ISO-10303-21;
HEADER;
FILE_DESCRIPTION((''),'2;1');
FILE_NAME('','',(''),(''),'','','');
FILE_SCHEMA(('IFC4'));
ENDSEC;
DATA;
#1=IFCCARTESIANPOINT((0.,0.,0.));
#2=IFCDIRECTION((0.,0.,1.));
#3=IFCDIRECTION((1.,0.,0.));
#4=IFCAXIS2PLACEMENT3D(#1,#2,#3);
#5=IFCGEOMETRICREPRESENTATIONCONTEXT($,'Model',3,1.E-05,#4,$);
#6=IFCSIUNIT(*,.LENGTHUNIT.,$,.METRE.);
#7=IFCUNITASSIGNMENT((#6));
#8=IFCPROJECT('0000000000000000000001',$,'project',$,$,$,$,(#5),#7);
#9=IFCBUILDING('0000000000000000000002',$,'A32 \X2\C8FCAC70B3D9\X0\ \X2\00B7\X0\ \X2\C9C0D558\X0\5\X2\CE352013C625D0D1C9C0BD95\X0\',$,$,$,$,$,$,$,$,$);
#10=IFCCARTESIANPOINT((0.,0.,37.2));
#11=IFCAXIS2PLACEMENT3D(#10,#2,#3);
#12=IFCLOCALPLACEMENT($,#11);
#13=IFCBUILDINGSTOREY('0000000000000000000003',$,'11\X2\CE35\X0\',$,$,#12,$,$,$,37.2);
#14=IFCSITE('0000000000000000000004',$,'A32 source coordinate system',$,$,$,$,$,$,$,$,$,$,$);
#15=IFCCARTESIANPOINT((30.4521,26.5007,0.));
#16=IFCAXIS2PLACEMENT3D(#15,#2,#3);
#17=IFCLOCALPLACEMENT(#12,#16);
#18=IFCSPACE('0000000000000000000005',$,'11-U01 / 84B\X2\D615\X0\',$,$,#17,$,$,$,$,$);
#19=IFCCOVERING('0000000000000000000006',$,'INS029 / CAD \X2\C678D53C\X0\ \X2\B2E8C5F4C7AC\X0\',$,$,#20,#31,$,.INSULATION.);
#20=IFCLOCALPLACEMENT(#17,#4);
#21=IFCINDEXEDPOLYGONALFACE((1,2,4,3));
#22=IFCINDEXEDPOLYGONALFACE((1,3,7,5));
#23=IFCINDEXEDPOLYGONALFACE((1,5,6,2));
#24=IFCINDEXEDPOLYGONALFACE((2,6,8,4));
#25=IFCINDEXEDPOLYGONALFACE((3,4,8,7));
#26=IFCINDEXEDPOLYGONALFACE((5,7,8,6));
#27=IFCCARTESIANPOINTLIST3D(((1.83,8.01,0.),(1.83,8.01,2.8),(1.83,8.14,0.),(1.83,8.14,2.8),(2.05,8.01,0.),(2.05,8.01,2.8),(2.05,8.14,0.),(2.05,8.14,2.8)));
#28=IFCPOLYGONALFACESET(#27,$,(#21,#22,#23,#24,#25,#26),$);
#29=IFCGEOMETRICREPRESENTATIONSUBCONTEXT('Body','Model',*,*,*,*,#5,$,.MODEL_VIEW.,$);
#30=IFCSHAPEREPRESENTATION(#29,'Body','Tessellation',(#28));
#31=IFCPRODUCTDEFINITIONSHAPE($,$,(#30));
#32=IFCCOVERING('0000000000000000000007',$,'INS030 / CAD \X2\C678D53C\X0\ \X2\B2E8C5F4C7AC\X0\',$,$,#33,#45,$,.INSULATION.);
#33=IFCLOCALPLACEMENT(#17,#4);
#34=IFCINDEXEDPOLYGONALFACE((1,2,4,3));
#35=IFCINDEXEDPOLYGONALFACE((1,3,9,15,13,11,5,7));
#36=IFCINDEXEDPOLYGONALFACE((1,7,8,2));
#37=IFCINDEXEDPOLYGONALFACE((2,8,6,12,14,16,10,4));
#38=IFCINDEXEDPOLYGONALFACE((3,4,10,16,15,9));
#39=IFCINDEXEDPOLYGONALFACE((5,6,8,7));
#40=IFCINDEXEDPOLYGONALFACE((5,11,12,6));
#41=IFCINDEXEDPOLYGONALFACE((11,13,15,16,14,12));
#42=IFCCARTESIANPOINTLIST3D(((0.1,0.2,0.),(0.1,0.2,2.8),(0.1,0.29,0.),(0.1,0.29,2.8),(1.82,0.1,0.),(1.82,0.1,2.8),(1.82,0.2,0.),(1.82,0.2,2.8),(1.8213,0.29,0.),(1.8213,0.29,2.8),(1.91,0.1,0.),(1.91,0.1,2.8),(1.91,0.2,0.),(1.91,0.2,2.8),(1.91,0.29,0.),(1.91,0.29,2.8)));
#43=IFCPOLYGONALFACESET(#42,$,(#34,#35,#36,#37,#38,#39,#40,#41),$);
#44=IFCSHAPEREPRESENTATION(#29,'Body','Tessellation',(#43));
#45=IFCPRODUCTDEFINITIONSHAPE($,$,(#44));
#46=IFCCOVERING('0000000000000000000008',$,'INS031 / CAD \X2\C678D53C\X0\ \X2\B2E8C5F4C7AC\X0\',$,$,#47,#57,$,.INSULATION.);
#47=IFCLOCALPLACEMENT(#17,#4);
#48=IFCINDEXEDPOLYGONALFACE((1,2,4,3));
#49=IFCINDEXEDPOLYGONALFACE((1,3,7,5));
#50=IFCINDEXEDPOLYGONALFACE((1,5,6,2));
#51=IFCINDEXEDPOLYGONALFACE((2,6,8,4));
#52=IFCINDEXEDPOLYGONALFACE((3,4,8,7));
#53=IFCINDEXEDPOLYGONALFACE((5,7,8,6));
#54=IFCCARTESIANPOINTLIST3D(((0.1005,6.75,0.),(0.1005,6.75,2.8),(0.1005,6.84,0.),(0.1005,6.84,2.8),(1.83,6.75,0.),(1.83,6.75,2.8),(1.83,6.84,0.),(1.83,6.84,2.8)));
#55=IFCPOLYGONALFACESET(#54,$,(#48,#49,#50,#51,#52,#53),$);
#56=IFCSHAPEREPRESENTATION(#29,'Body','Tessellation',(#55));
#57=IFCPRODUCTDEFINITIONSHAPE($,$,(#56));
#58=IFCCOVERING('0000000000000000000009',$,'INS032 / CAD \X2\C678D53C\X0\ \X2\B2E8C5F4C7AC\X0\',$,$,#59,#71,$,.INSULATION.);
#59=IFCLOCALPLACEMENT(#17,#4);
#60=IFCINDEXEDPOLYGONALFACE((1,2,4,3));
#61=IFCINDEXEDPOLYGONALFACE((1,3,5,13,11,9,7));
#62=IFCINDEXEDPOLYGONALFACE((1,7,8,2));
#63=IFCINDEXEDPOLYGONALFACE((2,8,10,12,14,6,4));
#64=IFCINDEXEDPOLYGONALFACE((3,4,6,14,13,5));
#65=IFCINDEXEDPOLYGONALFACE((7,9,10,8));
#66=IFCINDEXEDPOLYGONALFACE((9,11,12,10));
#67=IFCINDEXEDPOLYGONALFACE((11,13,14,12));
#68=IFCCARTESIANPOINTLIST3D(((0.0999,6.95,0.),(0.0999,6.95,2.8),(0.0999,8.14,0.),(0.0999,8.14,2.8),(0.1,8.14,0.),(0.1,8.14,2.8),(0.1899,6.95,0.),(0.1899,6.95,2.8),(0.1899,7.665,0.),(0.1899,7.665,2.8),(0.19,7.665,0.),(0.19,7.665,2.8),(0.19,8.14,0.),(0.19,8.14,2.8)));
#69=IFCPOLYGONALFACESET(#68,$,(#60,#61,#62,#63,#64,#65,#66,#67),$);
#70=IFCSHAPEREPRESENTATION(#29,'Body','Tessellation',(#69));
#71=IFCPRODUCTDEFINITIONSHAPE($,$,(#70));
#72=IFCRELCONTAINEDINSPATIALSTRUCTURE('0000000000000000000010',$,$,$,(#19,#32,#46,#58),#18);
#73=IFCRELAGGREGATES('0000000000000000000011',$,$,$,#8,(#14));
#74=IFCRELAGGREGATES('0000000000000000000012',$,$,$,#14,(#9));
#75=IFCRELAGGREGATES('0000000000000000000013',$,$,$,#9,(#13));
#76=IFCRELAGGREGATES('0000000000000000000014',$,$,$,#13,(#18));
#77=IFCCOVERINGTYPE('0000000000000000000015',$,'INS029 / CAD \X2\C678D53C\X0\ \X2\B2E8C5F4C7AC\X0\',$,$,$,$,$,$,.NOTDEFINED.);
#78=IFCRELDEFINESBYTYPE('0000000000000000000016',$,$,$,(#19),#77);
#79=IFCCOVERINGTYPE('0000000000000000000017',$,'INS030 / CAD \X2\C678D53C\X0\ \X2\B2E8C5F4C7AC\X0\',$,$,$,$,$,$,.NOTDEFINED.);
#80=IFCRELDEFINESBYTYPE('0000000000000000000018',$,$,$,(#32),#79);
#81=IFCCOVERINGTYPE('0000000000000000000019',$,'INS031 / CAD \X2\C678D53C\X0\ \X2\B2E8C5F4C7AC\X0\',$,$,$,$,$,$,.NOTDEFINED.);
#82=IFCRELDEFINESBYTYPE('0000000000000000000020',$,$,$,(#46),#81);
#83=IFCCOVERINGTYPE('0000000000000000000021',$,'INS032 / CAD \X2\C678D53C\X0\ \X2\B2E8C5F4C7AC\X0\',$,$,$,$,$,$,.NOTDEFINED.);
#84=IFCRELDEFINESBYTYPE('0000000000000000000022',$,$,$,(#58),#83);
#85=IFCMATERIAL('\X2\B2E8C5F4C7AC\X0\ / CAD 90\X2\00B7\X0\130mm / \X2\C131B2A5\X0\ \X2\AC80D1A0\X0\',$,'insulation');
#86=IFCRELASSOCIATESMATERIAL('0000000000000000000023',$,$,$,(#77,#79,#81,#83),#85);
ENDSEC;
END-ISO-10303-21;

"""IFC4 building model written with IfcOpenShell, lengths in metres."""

from ifc_helpers import new_model, si_unit, frame, origin, origin_with_axes, place, context, subcontext, project, spatial, polyline, outline, extrude, source, transform, mapped, material, type_object, type_shapes, element, save


model = new_model("IFC4")

# Units and contexts
model_context = context("Model", 3, precision=1e-05, world=origin_with_axes())
body_context = subcontext(model_context, "Body", "Model", "MODEL_VIEW")
ifc_project = project(units=[si_unit("LENGTHUNIT", "METRE")], contexts=[model_context])

# Site, building, storey, space
storey_placement = place(None, frame((0.0, 0.0, 37.2), z_axis=(0.0, 0.0, 1.0), x_axis=(1.0, 0.0, 0.0)))
space_placement = place(storey_placement, frame((30.4521, 26.5007, 0.0), z_axis=(0.0, 0.0, 1.0), x_axis=(1.0, 0.0, 0.0)))
site = spatial("IfcSite", under=ifc_project, Name="A32 source coordinate system")
building = spatial("IfcBuilding", under=site, Name="A32 주거동 · 지하5층–옥탑지붕")
storey = spatial("IfcBuildingStorey", under=building, at=storey_placement, Name="11층", Elevation=37.2)
space = spatial("IfcSpace", under=storey, at=space_placement, Name="11-U01 / 84B형")

# Coverings
ifc_material = material(Name="단열재 / CAD 90·130mm / 성능 검토", Category="insulation")
covering_type_1 = type_object("IfcCoveringType", Name="INS029 / CAD 외피 단열재", PredefinedType="NOTDEFINED", material=ifc_material)
shared_shape_1 = source(origin(), body_context, "Body", "SweptSolid", [
    extrude(outline(polyline([(1.83, 8.01), (1.83, 8.14), (2.05, 8.14), (2.05, 8.01), (1.83, 8.01)])), origin(), (0.0, 0.0, 1.0), 2.8),
])
type_shapes(covering_type_1, [shared_shape_1])
covering_1_placement = place(space_placement, origin_with_axes())
element("IfcCovering", 1, at=covering_1_placement, inside=space, type_object=covering_type_1, Name="INS029 / CAD 외피 단열재", PredefinedType="INSULATION", context=body_context, shape_type="MappedRepresentation", body=[
    mapped(shared_shape_1, transform((0.0, 0.0, 0.0), scale=1.0)),
])
covering_type_2 = type_object("IfcCoveringType", Name="INS030 / CAD 외피 단열재", PredefinedType="NOTDEFINED", material=ifc_material)
shared_shape_2 = source(origin(), body_context, "Body", "SweptSolid", [
    extrude(outline(polyline([(1.91, 0.2), (1.91, 0.1), (1.82, 0.1), (1.82, 0.2), (0.1, 0.2), (0.1, 0.29), (1.8213, 0.29), (1.91, 0.29), (1.91, 0.2)])), origin(), (0.0, 0.0, 1.0), 2.8),
])
type_shapes(covering_type_2, [shared_shape_2])
covering_2_placement = place(space_placement, origin_with_axes())
element("IfcCovering", 2, at=covering_2_placement, inside=space, type_object=covering_type_2, Name="INS030 / CAD 외피 단열재", PredefinedType="INSULATION", context=body_context, shape_type="MappedRepresentation", body=[
    mapped(shared_shape_2, transform((0.0, 0.0, 0.0), scale=1.0)),
])
covering_type_3 = type_object("IfcCoveringType", Name="INS031 / CAD 외피 단열재", PredefinedType="NOTDEFINED", material=ifc_material)
shared_shape_3 = source(origin(), body_context, "Body", "SweptSolid", [
    extrude(outline(polyline([(1.83, 6.75), (0.1005, 6.75), (0.1005, 6.84), (1.83, 6.84), (1.83, 6.75)])), origin(), (0.0, 0.0, 1.0), 2.8),
])
type_shapes(covering_type_3, [shared_shape_3])
covering_3_placement = place(space_placement, origin_with_axes())
element("IfcCovering", 3, at=covering_3_placement, inside=space, type_object=covering_type_3, Name="INS031 / CAD 외피 단열재", PredefinedType="INSULATION", context=body_context, shape_type="MappedRepresentation", body=[
    mapped(shared_shape_3, transform((0.0, 0.0, 0.0), scale=1.0)),
])
covering_type_4 = type_object("IfcCoveringType", Name="INS032 / CAD 외피 단열재", PredefinedType="NOTDEFINED", material=ifc_material)
shared_shape_4 = source(origin(), body_context, "Body", "SweptSolid", [
    extrude(outline(polyline([(0.1899, 6.95), (0.0999, 6.95), (0.0999, 8.14), (0.1, 8.14), (0.19, 8.14), (0.19, 7.665), (0.1899, 7.665), (0.1899, 6.95)])), origin(), (0.0, 0.0, 1.0), 2.8),
])
type_shapes(covering_type_4, [shared_shape_4])
covering_4_placement = place(space_placement, origin_with_axes())
element("IfcCovering", 4, at=covering_4_placement, inside=space, type_object=covering_type_4, Name="INS032 / CAD 외피 단열재", PredefinedType="INSULATION", context=body_context, shape_type="MappedRepresentation", body=[
    mapped(shared_shape_4, transform((0.0, 0.0, 0.0), scale=1.0)),
])

save(model, "model.ifc")
